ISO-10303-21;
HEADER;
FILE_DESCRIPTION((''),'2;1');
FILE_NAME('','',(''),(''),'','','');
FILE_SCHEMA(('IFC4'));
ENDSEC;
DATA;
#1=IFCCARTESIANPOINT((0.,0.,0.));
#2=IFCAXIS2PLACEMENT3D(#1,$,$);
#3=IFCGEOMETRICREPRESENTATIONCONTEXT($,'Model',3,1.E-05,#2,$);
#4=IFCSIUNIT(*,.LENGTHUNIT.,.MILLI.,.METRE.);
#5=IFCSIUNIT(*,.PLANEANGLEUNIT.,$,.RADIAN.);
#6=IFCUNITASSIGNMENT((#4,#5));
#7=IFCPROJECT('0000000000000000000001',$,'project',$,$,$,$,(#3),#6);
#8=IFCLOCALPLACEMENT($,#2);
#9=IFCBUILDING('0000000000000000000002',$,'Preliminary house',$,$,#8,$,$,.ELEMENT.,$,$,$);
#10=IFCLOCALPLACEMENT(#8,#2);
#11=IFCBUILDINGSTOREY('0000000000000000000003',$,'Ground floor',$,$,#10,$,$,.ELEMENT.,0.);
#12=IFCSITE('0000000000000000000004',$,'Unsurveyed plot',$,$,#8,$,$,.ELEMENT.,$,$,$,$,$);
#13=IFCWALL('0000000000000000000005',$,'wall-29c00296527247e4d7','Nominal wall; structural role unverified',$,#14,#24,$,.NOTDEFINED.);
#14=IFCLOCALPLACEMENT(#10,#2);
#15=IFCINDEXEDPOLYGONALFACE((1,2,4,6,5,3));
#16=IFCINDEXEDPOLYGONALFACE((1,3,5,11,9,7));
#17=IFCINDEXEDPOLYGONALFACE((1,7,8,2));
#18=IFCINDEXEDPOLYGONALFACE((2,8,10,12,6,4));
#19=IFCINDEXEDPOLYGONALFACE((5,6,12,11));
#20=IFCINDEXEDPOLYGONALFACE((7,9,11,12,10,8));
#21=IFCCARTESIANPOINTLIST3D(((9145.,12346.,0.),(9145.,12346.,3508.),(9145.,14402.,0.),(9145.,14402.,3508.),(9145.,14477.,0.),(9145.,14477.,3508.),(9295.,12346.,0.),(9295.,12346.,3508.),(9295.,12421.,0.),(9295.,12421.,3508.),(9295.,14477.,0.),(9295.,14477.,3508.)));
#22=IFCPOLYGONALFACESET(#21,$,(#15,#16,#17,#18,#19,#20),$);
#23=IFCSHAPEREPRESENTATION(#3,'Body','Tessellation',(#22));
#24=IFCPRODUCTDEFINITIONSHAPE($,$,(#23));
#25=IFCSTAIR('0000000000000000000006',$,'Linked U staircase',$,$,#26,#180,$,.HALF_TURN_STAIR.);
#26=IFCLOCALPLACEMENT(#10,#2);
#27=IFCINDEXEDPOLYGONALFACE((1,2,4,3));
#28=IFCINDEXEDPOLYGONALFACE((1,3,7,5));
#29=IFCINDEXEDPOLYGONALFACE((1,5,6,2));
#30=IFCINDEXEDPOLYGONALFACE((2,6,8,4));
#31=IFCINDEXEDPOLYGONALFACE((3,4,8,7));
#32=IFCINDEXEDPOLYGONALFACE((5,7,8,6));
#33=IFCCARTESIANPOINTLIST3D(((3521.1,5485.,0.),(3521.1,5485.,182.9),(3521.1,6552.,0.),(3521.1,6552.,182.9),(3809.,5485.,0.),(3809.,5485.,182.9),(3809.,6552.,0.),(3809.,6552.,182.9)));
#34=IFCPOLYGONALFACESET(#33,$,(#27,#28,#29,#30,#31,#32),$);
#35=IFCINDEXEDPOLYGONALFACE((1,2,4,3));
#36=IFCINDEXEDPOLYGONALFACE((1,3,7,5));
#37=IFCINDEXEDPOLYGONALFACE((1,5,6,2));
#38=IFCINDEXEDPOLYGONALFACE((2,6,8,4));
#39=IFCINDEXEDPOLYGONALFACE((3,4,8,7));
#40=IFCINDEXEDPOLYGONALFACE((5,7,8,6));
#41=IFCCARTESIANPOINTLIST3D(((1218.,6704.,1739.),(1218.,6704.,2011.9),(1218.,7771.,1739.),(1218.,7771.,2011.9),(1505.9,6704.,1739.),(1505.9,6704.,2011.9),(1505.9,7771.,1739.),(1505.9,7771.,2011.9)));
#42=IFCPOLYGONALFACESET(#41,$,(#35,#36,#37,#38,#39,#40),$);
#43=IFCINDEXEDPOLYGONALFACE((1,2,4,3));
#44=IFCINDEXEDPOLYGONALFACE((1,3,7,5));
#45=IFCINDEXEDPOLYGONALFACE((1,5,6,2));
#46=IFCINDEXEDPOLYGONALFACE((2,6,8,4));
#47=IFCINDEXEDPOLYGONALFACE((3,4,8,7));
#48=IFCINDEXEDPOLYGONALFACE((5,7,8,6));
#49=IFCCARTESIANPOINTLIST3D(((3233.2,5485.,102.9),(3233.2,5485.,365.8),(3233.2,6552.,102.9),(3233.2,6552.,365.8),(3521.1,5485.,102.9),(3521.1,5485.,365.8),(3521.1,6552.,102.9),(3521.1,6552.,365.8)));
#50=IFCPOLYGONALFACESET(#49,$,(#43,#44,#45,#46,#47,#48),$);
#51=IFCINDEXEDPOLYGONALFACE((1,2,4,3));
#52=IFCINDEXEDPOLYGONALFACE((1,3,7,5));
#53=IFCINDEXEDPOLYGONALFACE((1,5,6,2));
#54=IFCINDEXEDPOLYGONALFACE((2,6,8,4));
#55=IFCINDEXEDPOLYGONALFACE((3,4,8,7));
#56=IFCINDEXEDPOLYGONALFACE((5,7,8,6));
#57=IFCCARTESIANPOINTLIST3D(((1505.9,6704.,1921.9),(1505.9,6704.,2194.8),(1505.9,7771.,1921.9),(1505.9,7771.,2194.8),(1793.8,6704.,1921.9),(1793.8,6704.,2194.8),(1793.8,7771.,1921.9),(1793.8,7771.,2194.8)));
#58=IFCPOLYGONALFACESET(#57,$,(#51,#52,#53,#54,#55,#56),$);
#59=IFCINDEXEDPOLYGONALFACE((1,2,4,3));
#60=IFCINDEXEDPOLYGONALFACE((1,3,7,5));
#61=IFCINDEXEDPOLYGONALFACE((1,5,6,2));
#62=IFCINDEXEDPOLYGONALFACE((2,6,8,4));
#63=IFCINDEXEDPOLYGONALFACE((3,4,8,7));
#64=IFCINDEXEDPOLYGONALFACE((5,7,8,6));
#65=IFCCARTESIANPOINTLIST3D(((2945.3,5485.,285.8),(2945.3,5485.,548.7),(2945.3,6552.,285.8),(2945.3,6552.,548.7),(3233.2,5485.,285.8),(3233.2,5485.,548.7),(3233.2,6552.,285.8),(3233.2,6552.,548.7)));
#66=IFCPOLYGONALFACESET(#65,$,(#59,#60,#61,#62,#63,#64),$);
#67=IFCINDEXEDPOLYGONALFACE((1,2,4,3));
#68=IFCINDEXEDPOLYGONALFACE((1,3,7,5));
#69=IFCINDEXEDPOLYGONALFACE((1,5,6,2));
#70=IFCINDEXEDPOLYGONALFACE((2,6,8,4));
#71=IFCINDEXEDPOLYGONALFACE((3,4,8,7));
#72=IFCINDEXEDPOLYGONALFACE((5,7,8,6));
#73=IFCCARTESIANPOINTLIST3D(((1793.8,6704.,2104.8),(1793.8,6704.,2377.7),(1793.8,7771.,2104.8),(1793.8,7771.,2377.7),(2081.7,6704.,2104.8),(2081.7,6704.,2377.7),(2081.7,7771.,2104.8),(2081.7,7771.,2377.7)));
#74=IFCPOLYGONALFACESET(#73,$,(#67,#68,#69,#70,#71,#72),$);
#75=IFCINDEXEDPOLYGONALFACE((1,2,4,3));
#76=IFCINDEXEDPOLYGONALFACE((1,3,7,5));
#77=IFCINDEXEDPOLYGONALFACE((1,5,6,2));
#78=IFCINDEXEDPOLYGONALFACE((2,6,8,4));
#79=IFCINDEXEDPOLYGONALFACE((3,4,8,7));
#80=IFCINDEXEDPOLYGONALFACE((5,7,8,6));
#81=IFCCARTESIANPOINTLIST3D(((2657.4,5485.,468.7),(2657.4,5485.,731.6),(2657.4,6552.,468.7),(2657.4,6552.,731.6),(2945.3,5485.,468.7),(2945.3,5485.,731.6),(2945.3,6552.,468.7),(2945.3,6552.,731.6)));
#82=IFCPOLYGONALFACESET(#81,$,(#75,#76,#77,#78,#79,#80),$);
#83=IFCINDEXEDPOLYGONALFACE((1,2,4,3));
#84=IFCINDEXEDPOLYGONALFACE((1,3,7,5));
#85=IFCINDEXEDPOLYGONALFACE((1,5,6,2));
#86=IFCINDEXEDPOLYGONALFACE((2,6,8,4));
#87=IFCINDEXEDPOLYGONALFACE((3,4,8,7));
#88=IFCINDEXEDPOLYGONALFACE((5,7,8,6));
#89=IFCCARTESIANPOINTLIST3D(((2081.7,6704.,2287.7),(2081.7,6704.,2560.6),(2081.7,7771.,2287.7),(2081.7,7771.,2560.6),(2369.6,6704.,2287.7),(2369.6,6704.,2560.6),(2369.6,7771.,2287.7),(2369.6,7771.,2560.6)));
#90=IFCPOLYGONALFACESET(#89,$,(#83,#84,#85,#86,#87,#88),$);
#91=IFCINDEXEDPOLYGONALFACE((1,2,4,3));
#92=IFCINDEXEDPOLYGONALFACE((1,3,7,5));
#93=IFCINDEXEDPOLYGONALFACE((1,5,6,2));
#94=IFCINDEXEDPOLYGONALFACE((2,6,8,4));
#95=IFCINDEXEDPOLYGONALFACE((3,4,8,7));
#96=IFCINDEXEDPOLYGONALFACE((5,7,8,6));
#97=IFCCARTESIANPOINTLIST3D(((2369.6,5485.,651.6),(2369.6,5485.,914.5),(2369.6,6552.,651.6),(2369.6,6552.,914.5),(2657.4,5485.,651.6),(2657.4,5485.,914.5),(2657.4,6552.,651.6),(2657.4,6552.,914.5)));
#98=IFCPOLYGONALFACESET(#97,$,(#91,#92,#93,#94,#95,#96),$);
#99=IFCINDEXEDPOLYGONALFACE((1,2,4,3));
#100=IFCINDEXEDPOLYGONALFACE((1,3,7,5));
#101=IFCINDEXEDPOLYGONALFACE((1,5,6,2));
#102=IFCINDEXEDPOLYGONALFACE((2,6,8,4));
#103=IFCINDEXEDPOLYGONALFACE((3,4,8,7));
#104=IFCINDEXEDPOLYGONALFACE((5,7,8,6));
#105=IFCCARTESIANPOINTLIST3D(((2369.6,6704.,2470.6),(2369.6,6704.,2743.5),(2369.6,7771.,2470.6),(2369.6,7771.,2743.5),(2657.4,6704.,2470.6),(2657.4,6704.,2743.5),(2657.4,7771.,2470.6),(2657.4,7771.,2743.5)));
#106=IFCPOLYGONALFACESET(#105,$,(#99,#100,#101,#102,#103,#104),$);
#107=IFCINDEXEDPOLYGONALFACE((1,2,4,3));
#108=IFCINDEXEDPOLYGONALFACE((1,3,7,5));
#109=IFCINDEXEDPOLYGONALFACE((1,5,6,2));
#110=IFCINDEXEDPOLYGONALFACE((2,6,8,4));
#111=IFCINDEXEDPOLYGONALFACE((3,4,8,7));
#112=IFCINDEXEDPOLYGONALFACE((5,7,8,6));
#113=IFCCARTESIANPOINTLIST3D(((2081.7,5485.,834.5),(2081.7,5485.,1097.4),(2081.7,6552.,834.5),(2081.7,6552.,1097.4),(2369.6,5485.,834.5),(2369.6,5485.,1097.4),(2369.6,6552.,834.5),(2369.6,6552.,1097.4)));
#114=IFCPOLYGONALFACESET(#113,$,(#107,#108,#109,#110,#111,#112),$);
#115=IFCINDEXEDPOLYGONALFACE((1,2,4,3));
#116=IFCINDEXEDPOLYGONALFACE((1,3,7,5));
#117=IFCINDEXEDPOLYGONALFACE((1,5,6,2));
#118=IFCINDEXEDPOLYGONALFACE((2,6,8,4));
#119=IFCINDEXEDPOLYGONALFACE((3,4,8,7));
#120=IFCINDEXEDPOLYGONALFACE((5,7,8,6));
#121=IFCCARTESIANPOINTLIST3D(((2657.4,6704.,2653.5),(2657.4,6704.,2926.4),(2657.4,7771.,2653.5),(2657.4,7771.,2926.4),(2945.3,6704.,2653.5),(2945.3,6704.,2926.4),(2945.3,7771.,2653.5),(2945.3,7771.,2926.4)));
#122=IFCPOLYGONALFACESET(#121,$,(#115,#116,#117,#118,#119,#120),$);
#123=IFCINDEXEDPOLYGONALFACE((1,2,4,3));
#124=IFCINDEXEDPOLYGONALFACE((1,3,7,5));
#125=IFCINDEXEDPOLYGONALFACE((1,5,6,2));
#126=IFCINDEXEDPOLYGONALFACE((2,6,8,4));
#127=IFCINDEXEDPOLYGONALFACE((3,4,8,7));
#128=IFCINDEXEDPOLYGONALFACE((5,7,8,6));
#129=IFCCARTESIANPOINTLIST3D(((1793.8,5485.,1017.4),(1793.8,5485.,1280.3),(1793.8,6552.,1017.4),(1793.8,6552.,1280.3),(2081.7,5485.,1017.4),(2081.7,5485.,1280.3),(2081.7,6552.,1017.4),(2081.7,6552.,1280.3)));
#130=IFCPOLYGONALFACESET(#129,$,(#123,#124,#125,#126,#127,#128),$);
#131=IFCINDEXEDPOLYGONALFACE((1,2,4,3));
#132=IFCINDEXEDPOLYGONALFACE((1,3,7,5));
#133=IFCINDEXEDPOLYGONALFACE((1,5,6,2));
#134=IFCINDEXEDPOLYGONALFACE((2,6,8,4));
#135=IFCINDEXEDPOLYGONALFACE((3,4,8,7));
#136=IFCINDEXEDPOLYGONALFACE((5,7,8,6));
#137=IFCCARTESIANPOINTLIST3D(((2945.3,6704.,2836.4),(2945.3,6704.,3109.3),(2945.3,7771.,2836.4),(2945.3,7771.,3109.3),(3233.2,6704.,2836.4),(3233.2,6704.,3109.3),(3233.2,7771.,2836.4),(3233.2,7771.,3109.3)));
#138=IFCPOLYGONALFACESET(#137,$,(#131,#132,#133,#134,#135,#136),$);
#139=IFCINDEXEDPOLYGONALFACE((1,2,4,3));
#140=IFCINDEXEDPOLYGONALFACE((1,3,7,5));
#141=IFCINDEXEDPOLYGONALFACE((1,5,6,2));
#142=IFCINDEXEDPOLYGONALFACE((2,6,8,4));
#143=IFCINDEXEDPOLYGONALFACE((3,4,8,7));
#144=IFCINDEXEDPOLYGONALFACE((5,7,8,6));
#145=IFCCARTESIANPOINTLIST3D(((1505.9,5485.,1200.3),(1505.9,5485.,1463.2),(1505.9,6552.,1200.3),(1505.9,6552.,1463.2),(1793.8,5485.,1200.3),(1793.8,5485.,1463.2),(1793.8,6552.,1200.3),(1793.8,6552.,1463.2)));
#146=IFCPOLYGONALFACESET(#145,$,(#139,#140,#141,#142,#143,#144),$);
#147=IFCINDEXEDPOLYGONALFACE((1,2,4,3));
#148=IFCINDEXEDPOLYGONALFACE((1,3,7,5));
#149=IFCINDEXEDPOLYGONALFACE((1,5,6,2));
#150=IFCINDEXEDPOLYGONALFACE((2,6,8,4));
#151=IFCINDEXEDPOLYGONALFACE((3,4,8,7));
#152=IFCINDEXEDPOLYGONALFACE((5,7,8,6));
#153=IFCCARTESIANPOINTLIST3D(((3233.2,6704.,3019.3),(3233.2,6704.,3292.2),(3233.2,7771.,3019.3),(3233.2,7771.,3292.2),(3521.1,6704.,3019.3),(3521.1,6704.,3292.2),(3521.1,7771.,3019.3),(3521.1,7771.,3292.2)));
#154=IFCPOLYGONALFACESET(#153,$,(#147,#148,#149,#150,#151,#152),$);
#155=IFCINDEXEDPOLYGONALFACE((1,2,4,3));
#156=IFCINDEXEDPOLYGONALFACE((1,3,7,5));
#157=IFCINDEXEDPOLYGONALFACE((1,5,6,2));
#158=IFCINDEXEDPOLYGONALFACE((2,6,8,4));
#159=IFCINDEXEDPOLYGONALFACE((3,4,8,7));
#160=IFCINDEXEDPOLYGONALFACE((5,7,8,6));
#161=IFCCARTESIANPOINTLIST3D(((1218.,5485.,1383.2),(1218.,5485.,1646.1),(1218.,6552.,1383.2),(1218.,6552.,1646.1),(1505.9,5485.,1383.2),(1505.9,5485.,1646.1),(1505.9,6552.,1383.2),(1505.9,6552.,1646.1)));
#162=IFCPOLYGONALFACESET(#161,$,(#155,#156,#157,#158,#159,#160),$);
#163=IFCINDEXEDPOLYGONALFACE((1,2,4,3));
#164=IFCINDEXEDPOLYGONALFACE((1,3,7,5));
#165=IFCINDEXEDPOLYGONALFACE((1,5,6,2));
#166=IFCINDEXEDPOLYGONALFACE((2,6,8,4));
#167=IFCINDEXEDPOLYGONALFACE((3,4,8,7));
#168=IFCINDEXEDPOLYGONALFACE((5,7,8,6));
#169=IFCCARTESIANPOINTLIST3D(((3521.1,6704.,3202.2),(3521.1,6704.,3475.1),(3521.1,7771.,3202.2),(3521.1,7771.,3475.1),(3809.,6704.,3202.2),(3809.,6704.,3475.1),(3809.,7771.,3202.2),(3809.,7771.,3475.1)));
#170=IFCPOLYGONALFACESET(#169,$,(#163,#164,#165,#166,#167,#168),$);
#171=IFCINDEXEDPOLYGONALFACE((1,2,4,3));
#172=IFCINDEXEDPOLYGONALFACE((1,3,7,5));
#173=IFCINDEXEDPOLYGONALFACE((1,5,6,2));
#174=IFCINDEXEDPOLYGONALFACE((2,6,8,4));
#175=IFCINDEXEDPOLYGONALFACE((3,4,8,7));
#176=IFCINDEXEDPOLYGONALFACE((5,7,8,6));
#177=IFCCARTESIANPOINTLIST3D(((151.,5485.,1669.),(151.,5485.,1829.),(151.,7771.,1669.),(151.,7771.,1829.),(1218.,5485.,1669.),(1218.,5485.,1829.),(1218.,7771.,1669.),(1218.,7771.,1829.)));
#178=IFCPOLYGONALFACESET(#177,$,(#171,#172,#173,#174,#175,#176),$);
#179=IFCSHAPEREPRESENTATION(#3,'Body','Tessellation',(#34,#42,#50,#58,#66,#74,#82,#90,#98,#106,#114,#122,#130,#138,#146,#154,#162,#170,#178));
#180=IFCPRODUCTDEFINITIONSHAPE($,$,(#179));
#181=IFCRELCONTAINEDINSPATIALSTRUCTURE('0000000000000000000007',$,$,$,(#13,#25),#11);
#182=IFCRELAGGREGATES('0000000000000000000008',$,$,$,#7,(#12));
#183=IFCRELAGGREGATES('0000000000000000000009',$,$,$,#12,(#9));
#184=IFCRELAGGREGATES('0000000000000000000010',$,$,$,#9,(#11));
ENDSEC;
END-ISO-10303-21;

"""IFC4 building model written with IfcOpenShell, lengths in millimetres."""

from ifc_helpers import new_model, si_unit, frame, origin, place, context, project, spatial, polyline, outline, extrude, element, save


model = new_model("IFC4")

# Units and contexts
model_context = context("Model", 3, precision=1e-05, world=origin())
ifc_project = project(units=[si_unit("LENGTHUNIT", "METRE", prefix="MILLI"), si_unit("PLANEANGLEUNIT", "RADIAN")], contexts=[model_context])

# Site, building, storey
placement_1 = place(None, origin())
site = spatial("IfcSite", under=ifc_project, at=placement_1, Name="Unsurveyed plot", CompositionType="ELEMENT")
building = spatial("IfcBuilding", under=site, at=placement_1, Name="Preliminary house", CompositionType="ELEMENT")
placement_2 = place(placement_1, origin())
storey = spatial("IfcBuildingStorey", under=building, at=placement_2, Name="Ground floor", CompositionType="ELEMENT", Elevation=0.0)

# Wall
element("IfcWall", 1, at=placement_2, inside=storey, Name="wall-29c00296527247e4d7", Description="Nominal wall; structural role unverified", PredefinedType="NOTDEFINED", context=model_context, shape_type="SweptSolid", body=[
    extrude(outline(polyline([(9145.0, 14402.0), (9145.0, 14477.0), (9295.0, 14477.0), (9295.0, 12421.0), (9295.0, 12346.0), (9145.0, 12346.0), (9145.0, 14402.0)])), origin(), (0.0, 0.0, 1.0), 3508.0),
])

# Stair
element("IfcStair", 2, at=placement_2, inside=storey, Name="Linked U staircase", PredefinedType="HALF_TURN_STAIR", context=model_context, shape_type="SweptSolid", body=[
    extrude(outline(polyline([(3809.0, 6552.0), (3521.1, 6552.0), (3521.1, 5485.0), (3809.0, 5485.0), (3809.0, 6552.0)])), origin(), (0.0, 0.0, 1.0), 182.9),
    extrude(outline(polyline([(1505.9, 7771.0), (1218.0, 7771.0), (1218.0, 6704.0), (1505.9, 6704.0), (1505.9, 7771.0)])), frame((0.0, 0.0, 1739.0)), (0.0, 0.0, 1.0), 272.9),
    extrude(outline(polyline([(3521.1, 6552.0), (3233.2, 6552.0), (3233.2, 5485.0), (3521.1, 5485.0), (3521.1, 6552.0)])), frame((0.0, 0.0, 102.9)), (0.0, 0.0, 1.0), 262.9),
    extrude(outline(polyline([(1793.8, 7771.0), (1505.9, 7771.0), (1505.9, 6704.0), (1793.8, 6704.0), (1793.8, 7771.0)])), frame((0.0, 0.0, 1921.9)), (0.0, 0.0, 1.0), 272.9),
    extrude(outline(polyline([(3233.2, 6552.0), (2945.3, 6552.0), (2945.3, 5485.0), (3233.2, 5485.0), (3233.2, 6552.0)])), frame((0.0, 0.0, 285.8)), (0.0, 0.0, 1.0), 262.9),
    extrude(outline(polyline([(2081.7, 7771.0), (1793.8, 7771.0), (1793.8, 6704.0), (2081.7, 6704.0), (2081.7, 7771.0)])), frame((0.0, 0.0, 2104.8)), (0.0, 0.0, 1.0), 272.9),
    extrude(outline(polyline([(2945.3, 6552.0), (2657.4, 6552.0), (2657.4, 5485.0), (2945.3, 5485.0), (2945.3, 6552.0)])), frame((0.0, 0.0, 468.7)), (0.0, 0.0, 1.0), 262.9),
    extrude(outline(polyline([(2369.6, 7771.0), (2081.7, 7771.0), (2081.7, 6704.0), (2369.6, 6704.0), (2369.6, 7771.0)])), frame((0.0, 0.0, 2287.7)), (0.0, 0.0, 1.0), 272.9),
    extrude(outline(polyline([(2657.4, 6552.0), (2369.6, 6552.0), (2369.6, 5485.0), (2657.4, 5485.0), (2657.4, 6552.0)])), frame((0.0, 0.0, 651.6)), (0.0, 0.0, 1.0), 262.9),
    extrude(outline(polyline([(2657.4, 7771.0), (2369.6, 7771.0), (2369.6, 6704.0), (2657.4, 6704.0), (2657.4, 7771.0)])), frame((0.0, 0.0, 2470.6)), (0.0, 0.0, 1.0), 272.9),
    extrude(outline(polyline([(2369.6, 6552.0), (2081.7, 6552.0), (2081.7, 5485.0), (2369.6, 5485.0), (2369.6, 6552.0)])), frame((0.0, 0.0, 834.5)), (0.0, 0.0, 1.0), 262.9),
    extrude(outline(polyline([(2945.3, 7771.0), (2657.4, 7771.0), (2657.4, 6704.0), (2945.3, 6704.0), (2945.3, 7771.0)])), frame((0.0, 0.0, 2653.5)), (0.0, 0.0, 1.0), 272.9),
    extrude(outline(polyline([(2081.7, 6552.0), (1793.8, 6552.0), (1793.8, 5485.0), (2081.7, 5485.0), (2081.7, 6552.0)])), frame((0.0, 0.0, 1017.4)), (0.0, 0.0, 1.0), 262.9),
    extrude(outline(polyline([(3233.2, 7771.0), (2945.3, 7771.0), (2945.3, 6704.0), (3233.2, 6704.0), (3233.2, 7771.0)])), frame((0.0, 0.0, 2836.4)), (0.0, 0.0, 1.0), 272.9),
    extrude(outline(polyline([(1793.8, 6552.0), (1505.9, 6552.0), (1505.9, 5485.0), (1793.8, 5485.0), (1793.8, 6552.0)])), frame((0.0, 0.0, 1200.3)), (0.0, 0.0, 1.0), 262.9),
    extrude(outline(polyline([(3521.1, 7771.0), (3233.2, 7771.0), (3233.2, 6704.0), (3521.1, 6704.0), (3521.1, 7771.0)])), frame((0.0, 0.0, 3019.3)), (0.0, 0.0, 1.0), 272.9),
    extrude(outline(polyline([(1505.9, 6552.0), (1218.0, 6552.0), (1218.0, 5485.0), (1505.9, 5485.0), (1505.9, 6552.0)])), frame((0.0, 0.0, 1383.2)), (0.0, 0.0, 1.0), 262.9),
    extrude(outline(polyline([(3809.0, 7771.0), (3521.1, 7771.0), (3521.1, 6704.0), (3809.0, 6704.0), (3809.0, 7771.0)])), frame((0.0, 0.0, 3202.2)), (0.0, 0.0, 1.0), 272.9),
    extrude(outline(polyline([(1218.0, 7771.0), (151.0, 7771.0), (151.0, 5485.0), (1218.0, 5485.0), (1218.0, 7771.0)])), frame((0.0, 0.0, 1669.0)), (0.0, 0.0, 1.0), 160.0),
])

save(model, "model.ifc")
